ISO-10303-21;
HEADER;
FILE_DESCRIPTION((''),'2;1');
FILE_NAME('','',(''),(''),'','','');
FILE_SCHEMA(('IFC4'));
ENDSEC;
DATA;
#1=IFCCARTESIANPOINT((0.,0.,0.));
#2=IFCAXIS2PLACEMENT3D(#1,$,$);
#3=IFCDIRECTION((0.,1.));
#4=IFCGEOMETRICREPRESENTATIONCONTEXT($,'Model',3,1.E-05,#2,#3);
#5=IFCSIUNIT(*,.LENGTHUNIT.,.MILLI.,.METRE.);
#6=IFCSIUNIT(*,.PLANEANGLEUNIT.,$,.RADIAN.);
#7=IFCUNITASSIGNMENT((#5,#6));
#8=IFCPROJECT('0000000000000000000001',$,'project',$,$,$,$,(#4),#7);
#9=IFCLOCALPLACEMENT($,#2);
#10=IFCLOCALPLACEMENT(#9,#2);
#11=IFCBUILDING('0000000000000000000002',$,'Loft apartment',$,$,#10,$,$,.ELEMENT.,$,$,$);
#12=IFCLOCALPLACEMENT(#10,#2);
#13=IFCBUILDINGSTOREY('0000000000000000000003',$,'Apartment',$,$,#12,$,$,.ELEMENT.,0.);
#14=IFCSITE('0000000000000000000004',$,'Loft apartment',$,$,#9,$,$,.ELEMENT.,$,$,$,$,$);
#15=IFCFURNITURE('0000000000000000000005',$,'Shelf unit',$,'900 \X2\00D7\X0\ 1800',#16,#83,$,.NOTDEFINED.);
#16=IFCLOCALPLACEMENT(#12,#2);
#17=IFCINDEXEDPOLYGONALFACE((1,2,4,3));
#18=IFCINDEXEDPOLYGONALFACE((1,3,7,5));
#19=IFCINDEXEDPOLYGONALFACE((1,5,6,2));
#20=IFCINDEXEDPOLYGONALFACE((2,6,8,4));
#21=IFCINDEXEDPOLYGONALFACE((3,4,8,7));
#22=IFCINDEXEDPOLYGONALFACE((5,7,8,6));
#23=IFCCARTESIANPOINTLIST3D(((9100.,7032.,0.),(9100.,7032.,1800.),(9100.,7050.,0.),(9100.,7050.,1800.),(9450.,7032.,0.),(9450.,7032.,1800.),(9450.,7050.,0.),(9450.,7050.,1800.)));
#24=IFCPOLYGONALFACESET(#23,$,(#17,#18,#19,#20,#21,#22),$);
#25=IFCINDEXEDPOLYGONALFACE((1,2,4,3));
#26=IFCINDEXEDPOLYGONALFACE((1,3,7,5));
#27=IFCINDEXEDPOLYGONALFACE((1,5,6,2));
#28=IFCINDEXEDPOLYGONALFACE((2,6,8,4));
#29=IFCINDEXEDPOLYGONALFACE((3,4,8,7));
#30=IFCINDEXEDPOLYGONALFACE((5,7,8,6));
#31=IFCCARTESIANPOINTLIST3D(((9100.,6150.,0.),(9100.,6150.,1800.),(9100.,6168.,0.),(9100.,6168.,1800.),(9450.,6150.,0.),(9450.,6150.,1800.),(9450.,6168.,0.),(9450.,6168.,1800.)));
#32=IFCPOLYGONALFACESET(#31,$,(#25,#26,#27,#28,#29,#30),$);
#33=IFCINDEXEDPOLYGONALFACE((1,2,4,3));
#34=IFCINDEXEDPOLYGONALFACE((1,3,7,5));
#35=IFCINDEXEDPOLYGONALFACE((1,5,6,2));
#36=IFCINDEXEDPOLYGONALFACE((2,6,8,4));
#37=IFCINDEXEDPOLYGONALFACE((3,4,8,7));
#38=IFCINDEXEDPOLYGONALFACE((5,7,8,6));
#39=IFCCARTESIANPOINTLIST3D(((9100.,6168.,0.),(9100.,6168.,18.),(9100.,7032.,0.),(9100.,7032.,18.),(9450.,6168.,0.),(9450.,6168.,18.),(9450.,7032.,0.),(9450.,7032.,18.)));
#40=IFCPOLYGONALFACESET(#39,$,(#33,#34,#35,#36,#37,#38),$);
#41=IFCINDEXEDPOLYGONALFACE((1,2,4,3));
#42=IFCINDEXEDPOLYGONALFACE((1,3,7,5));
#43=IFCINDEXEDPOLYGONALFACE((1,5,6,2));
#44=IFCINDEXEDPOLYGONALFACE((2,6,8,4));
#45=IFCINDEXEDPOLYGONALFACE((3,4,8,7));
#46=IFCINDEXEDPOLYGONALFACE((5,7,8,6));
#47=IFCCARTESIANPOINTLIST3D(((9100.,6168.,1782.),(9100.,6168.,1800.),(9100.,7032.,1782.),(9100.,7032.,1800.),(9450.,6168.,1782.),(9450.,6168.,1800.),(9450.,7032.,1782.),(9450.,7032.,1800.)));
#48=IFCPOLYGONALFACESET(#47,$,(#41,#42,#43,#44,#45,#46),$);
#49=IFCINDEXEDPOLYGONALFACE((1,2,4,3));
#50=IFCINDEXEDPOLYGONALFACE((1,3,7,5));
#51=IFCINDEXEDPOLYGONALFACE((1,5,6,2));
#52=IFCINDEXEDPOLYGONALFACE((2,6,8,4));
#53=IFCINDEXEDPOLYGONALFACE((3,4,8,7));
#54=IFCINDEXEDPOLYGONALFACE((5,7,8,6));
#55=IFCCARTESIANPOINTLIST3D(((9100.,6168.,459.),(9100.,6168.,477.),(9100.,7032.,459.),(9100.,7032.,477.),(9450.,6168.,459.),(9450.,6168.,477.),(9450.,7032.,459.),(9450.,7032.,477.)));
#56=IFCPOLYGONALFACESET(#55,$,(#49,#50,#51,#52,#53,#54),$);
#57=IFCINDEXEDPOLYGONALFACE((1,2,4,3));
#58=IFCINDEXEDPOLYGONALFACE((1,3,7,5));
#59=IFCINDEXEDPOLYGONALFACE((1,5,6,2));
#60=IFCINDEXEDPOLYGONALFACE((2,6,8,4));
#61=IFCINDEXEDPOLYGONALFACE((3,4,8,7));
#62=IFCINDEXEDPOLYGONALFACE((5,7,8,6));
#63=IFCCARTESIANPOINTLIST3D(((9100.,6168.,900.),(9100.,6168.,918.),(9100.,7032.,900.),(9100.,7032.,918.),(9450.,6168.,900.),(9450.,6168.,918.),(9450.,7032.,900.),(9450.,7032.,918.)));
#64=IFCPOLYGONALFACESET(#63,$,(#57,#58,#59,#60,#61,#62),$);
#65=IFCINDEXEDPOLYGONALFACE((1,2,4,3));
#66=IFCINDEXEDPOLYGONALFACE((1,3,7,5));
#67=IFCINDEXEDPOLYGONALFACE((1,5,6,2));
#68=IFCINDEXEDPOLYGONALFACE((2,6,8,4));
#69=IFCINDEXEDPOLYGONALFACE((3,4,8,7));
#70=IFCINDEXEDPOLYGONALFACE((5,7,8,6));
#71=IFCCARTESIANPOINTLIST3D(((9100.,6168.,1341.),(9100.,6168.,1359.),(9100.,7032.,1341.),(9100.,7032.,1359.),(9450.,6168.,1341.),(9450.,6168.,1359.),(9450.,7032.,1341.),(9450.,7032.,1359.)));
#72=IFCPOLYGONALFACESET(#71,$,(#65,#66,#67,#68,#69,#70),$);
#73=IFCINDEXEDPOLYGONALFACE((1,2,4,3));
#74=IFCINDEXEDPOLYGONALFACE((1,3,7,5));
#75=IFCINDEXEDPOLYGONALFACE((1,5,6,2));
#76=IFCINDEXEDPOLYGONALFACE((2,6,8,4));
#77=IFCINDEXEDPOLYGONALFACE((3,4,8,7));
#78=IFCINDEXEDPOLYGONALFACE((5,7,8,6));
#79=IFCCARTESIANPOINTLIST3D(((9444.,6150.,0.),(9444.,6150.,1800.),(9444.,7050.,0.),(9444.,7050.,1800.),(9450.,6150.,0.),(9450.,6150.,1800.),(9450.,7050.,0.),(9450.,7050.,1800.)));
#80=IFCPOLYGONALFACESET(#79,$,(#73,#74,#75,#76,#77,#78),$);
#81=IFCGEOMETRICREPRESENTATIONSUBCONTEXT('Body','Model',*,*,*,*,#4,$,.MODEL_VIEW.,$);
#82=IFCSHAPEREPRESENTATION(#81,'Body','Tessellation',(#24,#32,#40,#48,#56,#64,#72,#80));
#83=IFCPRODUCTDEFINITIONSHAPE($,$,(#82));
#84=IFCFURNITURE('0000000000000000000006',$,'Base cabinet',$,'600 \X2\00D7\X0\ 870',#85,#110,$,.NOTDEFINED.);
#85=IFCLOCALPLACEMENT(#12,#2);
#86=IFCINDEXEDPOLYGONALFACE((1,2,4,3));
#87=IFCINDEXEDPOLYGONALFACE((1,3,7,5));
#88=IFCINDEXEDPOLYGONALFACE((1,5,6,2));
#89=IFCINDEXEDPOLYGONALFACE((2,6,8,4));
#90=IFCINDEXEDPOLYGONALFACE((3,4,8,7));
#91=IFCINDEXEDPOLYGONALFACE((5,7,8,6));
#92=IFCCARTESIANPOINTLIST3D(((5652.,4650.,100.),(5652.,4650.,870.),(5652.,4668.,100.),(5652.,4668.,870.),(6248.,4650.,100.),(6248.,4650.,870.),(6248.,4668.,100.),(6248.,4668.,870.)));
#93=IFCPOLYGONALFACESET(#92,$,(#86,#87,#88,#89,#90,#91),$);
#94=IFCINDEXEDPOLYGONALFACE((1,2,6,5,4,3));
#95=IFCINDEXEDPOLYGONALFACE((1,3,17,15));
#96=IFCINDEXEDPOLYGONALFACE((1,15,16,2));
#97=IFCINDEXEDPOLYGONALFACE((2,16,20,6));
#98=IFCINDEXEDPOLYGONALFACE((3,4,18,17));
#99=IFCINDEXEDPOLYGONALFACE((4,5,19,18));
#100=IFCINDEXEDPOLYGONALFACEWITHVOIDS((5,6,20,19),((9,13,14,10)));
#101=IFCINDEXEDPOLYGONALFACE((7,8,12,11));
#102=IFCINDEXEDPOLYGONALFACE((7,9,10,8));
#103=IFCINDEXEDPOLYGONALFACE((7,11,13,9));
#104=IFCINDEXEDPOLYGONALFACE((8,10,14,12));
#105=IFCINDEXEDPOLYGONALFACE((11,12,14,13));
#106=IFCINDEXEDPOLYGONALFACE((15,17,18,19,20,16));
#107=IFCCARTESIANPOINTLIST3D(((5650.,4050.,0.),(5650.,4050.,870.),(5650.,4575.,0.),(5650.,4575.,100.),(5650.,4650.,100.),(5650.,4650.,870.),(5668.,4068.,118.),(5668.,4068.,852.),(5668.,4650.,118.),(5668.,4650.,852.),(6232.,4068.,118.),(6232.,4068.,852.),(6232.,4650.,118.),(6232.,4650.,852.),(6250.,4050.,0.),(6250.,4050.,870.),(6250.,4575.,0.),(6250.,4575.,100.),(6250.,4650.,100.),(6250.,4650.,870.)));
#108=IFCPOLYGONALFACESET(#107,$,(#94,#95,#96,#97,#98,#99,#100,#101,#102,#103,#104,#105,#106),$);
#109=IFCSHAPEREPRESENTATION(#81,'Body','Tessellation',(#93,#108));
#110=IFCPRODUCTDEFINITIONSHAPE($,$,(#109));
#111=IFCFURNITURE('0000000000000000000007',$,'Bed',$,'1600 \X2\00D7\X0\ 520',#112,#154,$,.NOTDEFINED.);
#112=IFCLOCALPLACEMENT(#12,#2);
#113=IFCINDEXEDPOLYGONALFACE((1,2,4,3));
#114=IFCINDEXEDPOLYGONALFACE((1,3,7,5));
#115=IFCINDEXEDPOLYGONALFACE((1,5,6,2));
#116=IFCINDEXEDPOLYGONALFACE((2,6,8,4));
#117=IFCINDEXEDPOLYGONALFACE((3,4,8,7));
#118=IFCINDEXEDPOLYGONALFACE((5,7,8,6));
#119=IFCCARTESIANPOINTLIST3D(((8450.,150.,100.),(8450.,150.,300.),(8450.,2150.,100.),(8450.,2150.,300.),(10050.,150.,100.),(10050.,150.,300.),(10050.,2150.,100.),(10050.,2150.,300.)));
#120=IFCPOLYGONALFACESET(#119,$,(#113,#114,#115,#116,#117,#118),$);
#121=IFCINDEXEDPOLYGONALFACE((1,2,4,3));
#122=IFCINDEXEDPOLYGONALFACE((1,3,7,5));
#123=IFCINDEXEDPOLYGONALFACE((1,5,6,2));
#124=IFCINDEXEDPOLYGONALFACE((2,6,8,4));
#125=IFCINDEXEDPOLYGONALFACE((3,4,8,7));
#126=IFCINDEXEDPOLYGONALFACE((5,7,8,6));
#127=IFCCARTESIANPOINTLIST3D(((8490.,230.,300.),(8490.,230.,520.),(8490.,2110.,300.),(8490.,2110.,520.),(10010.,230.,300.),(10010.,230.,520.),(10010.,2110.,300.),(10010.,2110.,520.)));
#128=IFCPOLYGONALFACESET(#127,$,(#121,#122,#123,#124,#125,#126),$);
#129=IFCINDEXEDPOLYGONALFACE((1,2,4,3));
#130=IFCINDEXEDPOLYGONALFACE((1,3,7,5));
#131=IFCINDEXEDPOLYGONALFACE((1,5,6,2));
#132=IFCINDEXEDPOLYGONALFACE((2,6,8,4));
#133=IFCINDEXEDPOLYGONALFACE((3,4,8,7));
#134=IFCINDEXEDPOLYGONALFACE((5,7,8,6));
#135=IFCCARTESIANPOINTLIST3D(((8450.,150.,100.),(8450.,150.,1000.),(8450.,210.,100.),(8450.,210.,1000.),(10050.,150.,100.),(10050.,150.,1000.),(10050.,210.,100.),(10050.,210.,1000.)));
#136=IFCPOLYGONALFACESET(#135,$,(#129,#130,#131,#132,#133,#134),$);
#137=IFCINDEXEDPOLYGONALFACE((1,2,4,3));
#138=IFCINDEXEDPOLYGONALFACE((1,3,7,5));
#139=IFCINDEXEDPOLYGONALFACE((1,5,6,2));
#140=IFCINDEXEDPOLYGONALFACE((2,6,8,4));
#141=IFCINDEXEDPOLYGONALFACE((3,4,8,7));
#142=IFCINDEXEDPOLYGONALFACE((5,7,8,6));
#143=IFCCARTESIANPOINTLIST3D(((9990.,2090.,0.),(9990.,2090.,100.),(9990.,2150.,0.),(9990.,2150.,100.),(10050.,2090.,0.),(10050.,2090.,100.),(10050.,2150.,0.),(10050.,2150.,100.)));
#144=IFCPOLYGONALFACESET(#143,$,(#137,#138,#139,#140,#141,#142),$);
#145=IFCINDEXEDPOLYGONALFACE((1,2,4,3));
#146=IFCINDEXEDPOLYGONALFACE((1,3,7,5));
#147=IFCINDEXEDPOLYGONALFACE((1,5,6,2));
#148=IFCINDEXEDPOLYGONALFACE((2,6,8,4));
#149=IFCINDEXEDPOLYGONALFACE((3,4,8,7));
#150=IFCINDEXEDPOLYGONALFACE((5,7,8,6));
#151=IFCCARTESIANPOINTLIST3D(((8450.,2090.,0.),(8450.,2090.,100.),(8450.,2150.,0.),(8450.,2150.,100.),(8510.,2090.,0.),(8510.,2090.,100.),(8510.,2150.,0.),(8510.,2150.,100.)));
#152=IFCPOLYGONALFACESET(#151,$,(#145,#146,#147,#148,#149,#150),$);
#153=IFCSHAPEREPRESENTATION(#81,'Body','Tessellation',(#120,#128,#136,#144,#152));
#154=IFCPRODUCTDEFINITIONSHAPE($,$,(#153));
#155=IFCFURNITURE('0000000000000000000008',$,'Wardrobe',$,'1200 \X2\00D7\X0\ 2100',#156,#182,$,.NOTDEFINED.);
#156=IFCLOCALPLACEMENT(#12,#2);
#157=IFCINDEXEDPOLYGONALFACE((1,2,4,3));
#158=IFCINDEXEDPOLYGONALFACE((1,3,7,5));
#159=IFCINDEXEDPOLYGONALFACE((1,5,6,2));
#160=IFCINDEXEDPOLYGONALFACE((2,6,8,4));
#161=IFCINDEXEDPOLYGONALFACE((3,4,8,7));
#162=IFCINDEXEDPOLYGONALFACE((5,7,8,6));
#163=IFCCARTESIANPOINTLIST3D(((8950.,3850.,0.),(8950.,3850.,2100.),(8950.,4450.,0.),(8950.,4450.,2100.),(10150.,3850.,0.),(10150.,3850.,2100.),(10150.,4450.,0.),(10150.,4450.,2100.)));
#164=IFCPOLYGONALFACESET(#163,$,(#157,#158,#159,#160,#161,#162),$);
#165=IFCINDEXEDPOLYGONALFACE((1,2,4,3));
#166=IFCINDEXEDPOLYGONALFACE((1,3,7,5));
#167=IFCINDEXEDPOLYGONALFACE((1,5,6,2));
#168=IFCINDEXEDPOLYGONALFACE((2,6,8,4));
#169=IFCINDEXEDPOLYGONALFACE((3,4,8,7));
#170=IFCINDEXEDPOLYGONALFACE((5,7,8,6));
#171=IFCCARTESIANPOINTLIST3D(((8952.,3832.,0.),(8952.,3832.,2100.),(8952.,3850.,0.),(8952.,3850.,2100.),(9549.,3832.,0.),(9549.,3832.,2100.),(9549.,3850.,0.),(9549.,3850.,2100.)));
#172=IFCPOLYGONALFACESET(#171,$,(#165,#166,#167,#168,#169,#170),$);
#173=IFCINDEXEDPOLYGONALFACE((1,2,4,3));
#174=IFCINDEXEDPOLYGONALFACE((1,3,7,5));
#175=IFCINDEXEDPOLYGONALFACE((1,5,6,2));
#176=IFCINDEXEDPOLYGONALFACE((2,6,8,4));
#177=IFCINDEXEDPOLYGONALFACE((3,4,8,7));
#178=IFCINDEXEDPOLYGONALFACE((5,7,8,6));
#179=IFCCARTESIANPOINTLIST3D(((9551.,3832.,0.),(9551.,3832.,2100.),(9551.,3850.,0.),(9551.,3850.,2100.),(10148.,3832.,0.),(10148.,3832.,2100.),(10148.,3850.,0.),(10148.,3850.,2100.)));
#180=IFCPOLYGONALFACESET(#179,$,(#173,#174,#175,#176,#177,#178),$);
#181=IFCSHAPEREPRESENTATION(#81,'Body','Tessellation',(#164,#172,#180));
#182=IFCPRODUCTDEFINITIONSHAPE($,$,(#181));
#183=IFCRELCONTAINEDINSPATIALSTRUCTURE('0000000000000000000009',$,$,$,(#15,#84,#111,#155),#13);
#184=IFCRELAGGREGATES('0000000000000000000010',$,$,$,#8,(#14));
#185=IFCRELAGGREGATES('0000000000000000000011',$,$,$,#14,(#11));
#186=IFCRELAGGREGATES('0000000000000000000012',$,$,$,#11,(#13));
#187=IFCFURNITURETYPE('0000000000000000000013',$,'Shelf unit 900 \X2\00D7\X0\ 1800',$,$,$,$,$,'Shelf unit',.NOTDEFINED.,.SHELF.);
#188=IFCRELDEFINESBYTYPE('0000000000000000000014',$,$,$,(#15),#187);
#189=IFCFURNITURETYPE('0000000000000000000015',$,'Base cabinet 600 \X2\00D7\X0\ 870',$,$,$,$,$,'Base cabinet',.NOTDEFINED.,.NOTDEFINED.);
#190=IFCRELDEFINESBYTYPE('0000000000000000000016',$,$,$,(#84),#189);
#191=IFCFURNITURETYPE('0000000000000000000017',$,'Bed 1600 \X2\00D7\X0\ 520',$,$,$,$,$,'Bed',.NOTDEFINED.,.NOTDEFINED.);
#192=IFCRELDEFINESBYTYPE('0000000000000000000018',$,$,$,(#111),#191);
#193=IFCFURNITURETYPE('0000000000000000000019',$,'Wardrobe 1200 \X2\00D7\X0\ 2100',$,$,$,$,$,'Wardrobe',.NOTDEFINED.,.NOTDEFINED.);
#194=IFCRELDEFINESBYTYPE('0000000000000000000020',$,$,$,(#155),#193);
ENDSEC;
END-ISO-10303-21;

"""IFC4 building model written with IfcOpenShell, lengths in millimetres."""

from ifc_helpers import new_model, entity, si_unit, direction, frame, origin, place, context, subcontext, project, spatial, polyline, outline, extrude, source, transform, mapped, type_object, type_shapes, element, save


model = new_model("IFC4")

# Units and contexts
model_context = context("Model", 3, precision=1e-05, world=origin(), true_north=direction((0.0, 1.0)))
body_context = subcontext(model_context, "Body", "Model", "MODEL_VIEW")
ifc_project = project(units=[si_unit("LENGTHUNIT", "METRE", prefix="MILLI"), si_unit("PLANEANGLEUNIT", "RADIAN")], contexts=[model_context])

# Site, building, storey
site_placement = place(None, origin())
site = spatial("IfcSite", under=ifc_project, at=site_placement, Name="Loft apartment", CompositionType="ELEMENT")
building_placement = place(site_placement, origin())
building = spatial("IfcBuilding", under=site, at=building_placement, Name="Loft apartment", CompositionType="ELEMENT")
storey_placement = place(building_placement, origin())
storey = spatial("IfcBuildingStorey", under=building, at=storey_placement, Name="Apartment", CompositionType="ELEMENT", Elevation=0.0)

# Furniture
furniture_type_1 = type_object("IfcFurnitureType", Name="Shelf unit 900 × 1800", ElementType="Shelf unit", AssemblyPlace="NOTDEFINED", PredefinedType="SHELF")
shared_shape_1 = source(origin(), body_context, "Body", "SweptSolid", [
    extrude(outline(polyline([(-450.0, 0.0), (-432.0, 0.0), (-432.0, 350.0), (-450.0, 350.0), (-450.0, 0.0)])), origin(), (0.0, 0.0, 1.0), 1800.0),
    extrude(outline(polyline([(432.0, 0.0), (450.0, 0.0), (450.0, 350.0), (432.0, 350.0), (432.0, 0.0)])), origin(), (0.0, 0.0, 1.0), 1800.0),
    extrude(outline(polyline([(-432.0, 0.0), (432.0, 0.0), (432.0, 350.0), (-432.0, 350.0), (-432.0, 0.0)])), origin(), (0.0, 0.0, 1.0), 18.0),
    extrude(outline(polyline([(-432.0, 0.0), (432.0, 0.0), (432.0, 350.0), (-432.0, 350.0), (-432.0, 0.0)])), frame((0.0, 0.0, 1782.0)), (0.0, 0.0, 1.0), 18.0),
    extrude(outline(polyline([(-432.0, 0.0), (432.0, 0.0), (432.0, 350.0), (-432.0, 350.0), (-432.0, 0.0)])), frame((0.0, 0.0, 459.0)), (0.0, 0.0, 1.0), 18.0),
    extrude(outline(polyline([(-432.0, 0.0), (432.0, 0.0), (432.0, 350.0), (-432.0, 350.0), (-432.0, 0.0)])), frame((0.0, 0.0, 900.0)), (0.0, 0.0, 1.0), 18.0),
    extrude(outline(polyline([(-432.0, 0.0), (432.0, 0.0), (432.0, 350.0), (-432.0, 350.0), (-432.0, 0.0)])), frame((0.0, 0.0, 1341.0)), (0.0, 0.0, 1.0), 18.0),
    extrude(outline(polyline([(-450.0, 344.0), (450.0, 344.0), (450.0, 350.0), (-450.0, 350.0), (-450.0, 344.0)])), origin(), (0.0, 0.0, 1.0), 1800.0),
])
type_shapes(furniture_type_1, [shared_shape_1])
for number, where, z_axis, x_axis, name in (
    (1, (9100.0, 6600.0, 0.0), (0.0, 0.0, 1.0), (0.0, -1.0, 0.0), "Shelf unit"),
):
    element("IfcFurniture", number, at=place(storey_placement, frame(where, z_axis=z_axis, x_axis=x_axis)), inside=storey, type_object=furniture_type_1, Name=name, ObjectType="900 × 1800", PredefinedType="NOTDEFINED", context=body_context, shape_type="MappedRepresentation", body=[
        mapped(shared_shape_1, transform((0.0, 0.0, 0.0))),
    ])
furniture_type_2 = type_object("IfcFurnitureType", Name="Base cabinet 600 × 870", ElementType="Base cabinet", AssemblyPlace="NOTDEFINED", PredefinedType="NOTDEFINED")
cartesian_point_1 = entity("IfcCartesianPoint", [-300.0, 0.0])
cartesian_point_2 = entity("IfcCartesianPoint", [-282.0, -1.0])
cartesian_point_3 = entity("IfcCartesianPoint", [-301.0, -1.0])
shared_shape_2 = source(origin(), body_context, "Body", "SolidModel", [
    extrude(outline(polyline([(-298.0, -18.0), (298.0, -18.0), (298.0, 0.0), (-298.0, 0.0), (-298.0, -18.0)])), frame((0.0, 0.0, 100.0)), (0.0, 0.0, 1.0), 770.0),
    entity("IfcCsgSolid", entity("IfcBooleanResult", "DIFFERENCE", entity("IfcBooleanResult", "DIFFERENCE", entity("IfcExtrudedAreaSolid", entity("IfcArbitraryClosedProfileDef", "AREA", None, entity("IfcPolyline", [cartesian_point_1, entity("IfcCartesianPoint", [300.0, 0.0]), entity("IfcCartesianPoint", [300.0, 600.0]), entity("IfcCartesianPoint", [-300.0, 600.0]), cartesian_point_1])), entity("IfcAxis2Placement3D", entity("IfcCartesianPoint", [0.0, 0.0, 0.0])), entity("IfcDirection", [0.0, 0.0, 1.0]), 870.0), entity("IfcExtrudedAreaSolid", entity("IfcArbitraryClosedProfileDef", "AREA", None, entity("IfcPolyline", [cartesian_point_2, entity("IfcCartesianPoint", [282.0, -1.0]), entity("IfcCartesianPoint", [282.0, 582.0]), entity("IfcCartesianPoint", [-282.0, 582.0]), cartesian_point_2])), entity("IfcAxis2Placement3D", entity("IfcCartesianPoint", [0.0, 0.0, 118.0])), entity("IfcDirection", [0.0, 0.0, 1.0]), 734.0)), entity("IfcExtrudedAreaSolid", entity("IfcArbitraryClosedProfileDef", "AREA", None, entity("IfcPolyline", [cartesian_point_3, entity("IfcCartesianPoint", [301.0, -1.0]), entity("IfcCartesianPoint", [301.0, 75.0]), entity("IfcCartesianPoint", [-301.0, 75.0]), cartesian_point_3])), entity("IfcAxis2Placement3D", entity("IfcCartesianPoint", [0.0, 0.0, -1.0])), entity("IfcDirection", [0.0, 0.0, 1.0]), 101.0))),
])
type_shapes(furniture_type_2, [shared_shape_2])
furniture_1_placement = place(storey_placement, frame((5950.0, 4650.0, 0.0), z_axis=(0.0, 0.0, 1.0), x_axis=(-1.0, 0.0, 0.0)))
element("IfcFurniture", 2, at=furniture_1_placement, inside=storey, type_object=furniture_type_2, Name="Base cabinet", ObjectType="600 × 870", PredefinedType="NOTDEFINED", context=body_context, shape_type="MappedRepresentation", body=[
    mapped(shared_shape_2, transform((0.0, 0.0, 0.0))),
])
furniture_type_3 = type_object("IfcFurnitureType", Name="Bed 1600 × 520", ElementType="Bed", AssemblyPlace="NOTDEFINED", PredefinedType="NOTDEFINED")
shared_shape_3 = source(origin(), body_context, "Body", "SweptSolid", [
    extrude(outline(polyline([(-800.0, 0.0), (800.0, 0.0), (800.0, 2000.0), (-800.0, 2000.0), (-800.0, 0.0)])), frame((0.0, 0.0, 100.0)), (0.0, 0.0, 1.0), 200.0),
    extrude(outline(polyline([(-760.0, 40.0), (760.0, 40.0), (760.0, 1920.0), (-760.0, 1920.0), (-760.0, 40.0)])), frame((0.0, 0.0, 300.0)), (0.0, 0.0, 1.0), 220.0),
    extrude(outline(polyline([(-800.0, 1940.0), (800.0, 1940.0), (800.0, 2000.0), (-800.0, 2000.0), (-800.0, 1940.0)])), frame((0.0, 0.0, 100.0)), (0.0, 0.0, 1.0), 900.0),
    extrude(outline(polyline([(-800.0, 0.0), (-740.0, 0.0), (-740.0, 60.0), (-800.0, 60.0), (-800.0, 0.0)])), origin(), (0.0, 0.0, 1.0), 100.0),
    extrude(outline(polyline([(740.0, 0.0), (800.0, 0.0), (800.0, 60.0), (740.0, 60.0), (740.0, 0.0)])), origin(), (0.0, 0.0, 1.0), 100.0),
])
type_shapes(furniture_type_3, [shared_shape_3])
furniture_2_placement = place(storey_placement, frame((9250.0, 2150.0, 0.0), z_axis=(0.0, 0.0, 1.0), x_axis=(-1.0, 0.0, 0.0)))
element("IfcFurniture", 3, at=furniture_2_placement, inside=storey, type_object=furniture_type_3, Name="Bed", ObjectType="1600 × 520", PredefinedType="NOTDEFINED", context=body_context, shape_type="MappedRepresentation", body=[
    mapped(shared_shape_3, transform((0.0, 0.0, 0.0))),
])
furniture_type_4 = type_object("IfcFurnitureType", Name="Wardrobe 1200 × 2100", ElementType="Wardrobe", AssemblyPlace="NOTDEFINED", PredefinedType="NOTDEFINED")
shared_shape_4 = source(origin(), body_context, "Body", "SweptSolid", [
    extrude(outline(polyline([(-600.0, 0.0), (600.0, 0.0), (600.0, 600.0), (-600.0, 600.0), (-600.0, 0.0)])), origin(), (0.0, 0.0, 1.0), 2100.0),
    extrude(outline(polyline([(-598.0, -18.0), (-1.0, -18.0), (-1.0, 0.0), (-598.0, 0.0), (-598.0, -18.0)])), origin(), (0.0, 0.0, 1.0), 2100.0),
    extrude(outline(polyline([(1.0, -18.0), (598.0, -18.0), (598.0, 0.0), (1.0, 0.0), (1.0, -18.0)])), origin(), (0.0, 0.0, 1.0), 2100.0),
])
type_shapes(furniture_type_4, [shared_shape_4])
furniture_3_placement = place(storey_placement, frame((9550.0, 3850.0, 0.0), z_axis=(0.0, 0.0, 1.0), x_axis=(1.0, 0.0, 0.0)))
element("IfcFurniture", 4, at=furniture_3_placement, inside=storey, type_object=furniture_type_4, Name="Wardrobe", ObjectType="1200 × 2100", PredefinedType="NOTDEFINED", context=body_context, shape_type="MappedRepresentation", body=[
    mapped(shared_shape_4, transform((0.0, 0.0, 0.0))),
])

save(model, "model.ifc")
